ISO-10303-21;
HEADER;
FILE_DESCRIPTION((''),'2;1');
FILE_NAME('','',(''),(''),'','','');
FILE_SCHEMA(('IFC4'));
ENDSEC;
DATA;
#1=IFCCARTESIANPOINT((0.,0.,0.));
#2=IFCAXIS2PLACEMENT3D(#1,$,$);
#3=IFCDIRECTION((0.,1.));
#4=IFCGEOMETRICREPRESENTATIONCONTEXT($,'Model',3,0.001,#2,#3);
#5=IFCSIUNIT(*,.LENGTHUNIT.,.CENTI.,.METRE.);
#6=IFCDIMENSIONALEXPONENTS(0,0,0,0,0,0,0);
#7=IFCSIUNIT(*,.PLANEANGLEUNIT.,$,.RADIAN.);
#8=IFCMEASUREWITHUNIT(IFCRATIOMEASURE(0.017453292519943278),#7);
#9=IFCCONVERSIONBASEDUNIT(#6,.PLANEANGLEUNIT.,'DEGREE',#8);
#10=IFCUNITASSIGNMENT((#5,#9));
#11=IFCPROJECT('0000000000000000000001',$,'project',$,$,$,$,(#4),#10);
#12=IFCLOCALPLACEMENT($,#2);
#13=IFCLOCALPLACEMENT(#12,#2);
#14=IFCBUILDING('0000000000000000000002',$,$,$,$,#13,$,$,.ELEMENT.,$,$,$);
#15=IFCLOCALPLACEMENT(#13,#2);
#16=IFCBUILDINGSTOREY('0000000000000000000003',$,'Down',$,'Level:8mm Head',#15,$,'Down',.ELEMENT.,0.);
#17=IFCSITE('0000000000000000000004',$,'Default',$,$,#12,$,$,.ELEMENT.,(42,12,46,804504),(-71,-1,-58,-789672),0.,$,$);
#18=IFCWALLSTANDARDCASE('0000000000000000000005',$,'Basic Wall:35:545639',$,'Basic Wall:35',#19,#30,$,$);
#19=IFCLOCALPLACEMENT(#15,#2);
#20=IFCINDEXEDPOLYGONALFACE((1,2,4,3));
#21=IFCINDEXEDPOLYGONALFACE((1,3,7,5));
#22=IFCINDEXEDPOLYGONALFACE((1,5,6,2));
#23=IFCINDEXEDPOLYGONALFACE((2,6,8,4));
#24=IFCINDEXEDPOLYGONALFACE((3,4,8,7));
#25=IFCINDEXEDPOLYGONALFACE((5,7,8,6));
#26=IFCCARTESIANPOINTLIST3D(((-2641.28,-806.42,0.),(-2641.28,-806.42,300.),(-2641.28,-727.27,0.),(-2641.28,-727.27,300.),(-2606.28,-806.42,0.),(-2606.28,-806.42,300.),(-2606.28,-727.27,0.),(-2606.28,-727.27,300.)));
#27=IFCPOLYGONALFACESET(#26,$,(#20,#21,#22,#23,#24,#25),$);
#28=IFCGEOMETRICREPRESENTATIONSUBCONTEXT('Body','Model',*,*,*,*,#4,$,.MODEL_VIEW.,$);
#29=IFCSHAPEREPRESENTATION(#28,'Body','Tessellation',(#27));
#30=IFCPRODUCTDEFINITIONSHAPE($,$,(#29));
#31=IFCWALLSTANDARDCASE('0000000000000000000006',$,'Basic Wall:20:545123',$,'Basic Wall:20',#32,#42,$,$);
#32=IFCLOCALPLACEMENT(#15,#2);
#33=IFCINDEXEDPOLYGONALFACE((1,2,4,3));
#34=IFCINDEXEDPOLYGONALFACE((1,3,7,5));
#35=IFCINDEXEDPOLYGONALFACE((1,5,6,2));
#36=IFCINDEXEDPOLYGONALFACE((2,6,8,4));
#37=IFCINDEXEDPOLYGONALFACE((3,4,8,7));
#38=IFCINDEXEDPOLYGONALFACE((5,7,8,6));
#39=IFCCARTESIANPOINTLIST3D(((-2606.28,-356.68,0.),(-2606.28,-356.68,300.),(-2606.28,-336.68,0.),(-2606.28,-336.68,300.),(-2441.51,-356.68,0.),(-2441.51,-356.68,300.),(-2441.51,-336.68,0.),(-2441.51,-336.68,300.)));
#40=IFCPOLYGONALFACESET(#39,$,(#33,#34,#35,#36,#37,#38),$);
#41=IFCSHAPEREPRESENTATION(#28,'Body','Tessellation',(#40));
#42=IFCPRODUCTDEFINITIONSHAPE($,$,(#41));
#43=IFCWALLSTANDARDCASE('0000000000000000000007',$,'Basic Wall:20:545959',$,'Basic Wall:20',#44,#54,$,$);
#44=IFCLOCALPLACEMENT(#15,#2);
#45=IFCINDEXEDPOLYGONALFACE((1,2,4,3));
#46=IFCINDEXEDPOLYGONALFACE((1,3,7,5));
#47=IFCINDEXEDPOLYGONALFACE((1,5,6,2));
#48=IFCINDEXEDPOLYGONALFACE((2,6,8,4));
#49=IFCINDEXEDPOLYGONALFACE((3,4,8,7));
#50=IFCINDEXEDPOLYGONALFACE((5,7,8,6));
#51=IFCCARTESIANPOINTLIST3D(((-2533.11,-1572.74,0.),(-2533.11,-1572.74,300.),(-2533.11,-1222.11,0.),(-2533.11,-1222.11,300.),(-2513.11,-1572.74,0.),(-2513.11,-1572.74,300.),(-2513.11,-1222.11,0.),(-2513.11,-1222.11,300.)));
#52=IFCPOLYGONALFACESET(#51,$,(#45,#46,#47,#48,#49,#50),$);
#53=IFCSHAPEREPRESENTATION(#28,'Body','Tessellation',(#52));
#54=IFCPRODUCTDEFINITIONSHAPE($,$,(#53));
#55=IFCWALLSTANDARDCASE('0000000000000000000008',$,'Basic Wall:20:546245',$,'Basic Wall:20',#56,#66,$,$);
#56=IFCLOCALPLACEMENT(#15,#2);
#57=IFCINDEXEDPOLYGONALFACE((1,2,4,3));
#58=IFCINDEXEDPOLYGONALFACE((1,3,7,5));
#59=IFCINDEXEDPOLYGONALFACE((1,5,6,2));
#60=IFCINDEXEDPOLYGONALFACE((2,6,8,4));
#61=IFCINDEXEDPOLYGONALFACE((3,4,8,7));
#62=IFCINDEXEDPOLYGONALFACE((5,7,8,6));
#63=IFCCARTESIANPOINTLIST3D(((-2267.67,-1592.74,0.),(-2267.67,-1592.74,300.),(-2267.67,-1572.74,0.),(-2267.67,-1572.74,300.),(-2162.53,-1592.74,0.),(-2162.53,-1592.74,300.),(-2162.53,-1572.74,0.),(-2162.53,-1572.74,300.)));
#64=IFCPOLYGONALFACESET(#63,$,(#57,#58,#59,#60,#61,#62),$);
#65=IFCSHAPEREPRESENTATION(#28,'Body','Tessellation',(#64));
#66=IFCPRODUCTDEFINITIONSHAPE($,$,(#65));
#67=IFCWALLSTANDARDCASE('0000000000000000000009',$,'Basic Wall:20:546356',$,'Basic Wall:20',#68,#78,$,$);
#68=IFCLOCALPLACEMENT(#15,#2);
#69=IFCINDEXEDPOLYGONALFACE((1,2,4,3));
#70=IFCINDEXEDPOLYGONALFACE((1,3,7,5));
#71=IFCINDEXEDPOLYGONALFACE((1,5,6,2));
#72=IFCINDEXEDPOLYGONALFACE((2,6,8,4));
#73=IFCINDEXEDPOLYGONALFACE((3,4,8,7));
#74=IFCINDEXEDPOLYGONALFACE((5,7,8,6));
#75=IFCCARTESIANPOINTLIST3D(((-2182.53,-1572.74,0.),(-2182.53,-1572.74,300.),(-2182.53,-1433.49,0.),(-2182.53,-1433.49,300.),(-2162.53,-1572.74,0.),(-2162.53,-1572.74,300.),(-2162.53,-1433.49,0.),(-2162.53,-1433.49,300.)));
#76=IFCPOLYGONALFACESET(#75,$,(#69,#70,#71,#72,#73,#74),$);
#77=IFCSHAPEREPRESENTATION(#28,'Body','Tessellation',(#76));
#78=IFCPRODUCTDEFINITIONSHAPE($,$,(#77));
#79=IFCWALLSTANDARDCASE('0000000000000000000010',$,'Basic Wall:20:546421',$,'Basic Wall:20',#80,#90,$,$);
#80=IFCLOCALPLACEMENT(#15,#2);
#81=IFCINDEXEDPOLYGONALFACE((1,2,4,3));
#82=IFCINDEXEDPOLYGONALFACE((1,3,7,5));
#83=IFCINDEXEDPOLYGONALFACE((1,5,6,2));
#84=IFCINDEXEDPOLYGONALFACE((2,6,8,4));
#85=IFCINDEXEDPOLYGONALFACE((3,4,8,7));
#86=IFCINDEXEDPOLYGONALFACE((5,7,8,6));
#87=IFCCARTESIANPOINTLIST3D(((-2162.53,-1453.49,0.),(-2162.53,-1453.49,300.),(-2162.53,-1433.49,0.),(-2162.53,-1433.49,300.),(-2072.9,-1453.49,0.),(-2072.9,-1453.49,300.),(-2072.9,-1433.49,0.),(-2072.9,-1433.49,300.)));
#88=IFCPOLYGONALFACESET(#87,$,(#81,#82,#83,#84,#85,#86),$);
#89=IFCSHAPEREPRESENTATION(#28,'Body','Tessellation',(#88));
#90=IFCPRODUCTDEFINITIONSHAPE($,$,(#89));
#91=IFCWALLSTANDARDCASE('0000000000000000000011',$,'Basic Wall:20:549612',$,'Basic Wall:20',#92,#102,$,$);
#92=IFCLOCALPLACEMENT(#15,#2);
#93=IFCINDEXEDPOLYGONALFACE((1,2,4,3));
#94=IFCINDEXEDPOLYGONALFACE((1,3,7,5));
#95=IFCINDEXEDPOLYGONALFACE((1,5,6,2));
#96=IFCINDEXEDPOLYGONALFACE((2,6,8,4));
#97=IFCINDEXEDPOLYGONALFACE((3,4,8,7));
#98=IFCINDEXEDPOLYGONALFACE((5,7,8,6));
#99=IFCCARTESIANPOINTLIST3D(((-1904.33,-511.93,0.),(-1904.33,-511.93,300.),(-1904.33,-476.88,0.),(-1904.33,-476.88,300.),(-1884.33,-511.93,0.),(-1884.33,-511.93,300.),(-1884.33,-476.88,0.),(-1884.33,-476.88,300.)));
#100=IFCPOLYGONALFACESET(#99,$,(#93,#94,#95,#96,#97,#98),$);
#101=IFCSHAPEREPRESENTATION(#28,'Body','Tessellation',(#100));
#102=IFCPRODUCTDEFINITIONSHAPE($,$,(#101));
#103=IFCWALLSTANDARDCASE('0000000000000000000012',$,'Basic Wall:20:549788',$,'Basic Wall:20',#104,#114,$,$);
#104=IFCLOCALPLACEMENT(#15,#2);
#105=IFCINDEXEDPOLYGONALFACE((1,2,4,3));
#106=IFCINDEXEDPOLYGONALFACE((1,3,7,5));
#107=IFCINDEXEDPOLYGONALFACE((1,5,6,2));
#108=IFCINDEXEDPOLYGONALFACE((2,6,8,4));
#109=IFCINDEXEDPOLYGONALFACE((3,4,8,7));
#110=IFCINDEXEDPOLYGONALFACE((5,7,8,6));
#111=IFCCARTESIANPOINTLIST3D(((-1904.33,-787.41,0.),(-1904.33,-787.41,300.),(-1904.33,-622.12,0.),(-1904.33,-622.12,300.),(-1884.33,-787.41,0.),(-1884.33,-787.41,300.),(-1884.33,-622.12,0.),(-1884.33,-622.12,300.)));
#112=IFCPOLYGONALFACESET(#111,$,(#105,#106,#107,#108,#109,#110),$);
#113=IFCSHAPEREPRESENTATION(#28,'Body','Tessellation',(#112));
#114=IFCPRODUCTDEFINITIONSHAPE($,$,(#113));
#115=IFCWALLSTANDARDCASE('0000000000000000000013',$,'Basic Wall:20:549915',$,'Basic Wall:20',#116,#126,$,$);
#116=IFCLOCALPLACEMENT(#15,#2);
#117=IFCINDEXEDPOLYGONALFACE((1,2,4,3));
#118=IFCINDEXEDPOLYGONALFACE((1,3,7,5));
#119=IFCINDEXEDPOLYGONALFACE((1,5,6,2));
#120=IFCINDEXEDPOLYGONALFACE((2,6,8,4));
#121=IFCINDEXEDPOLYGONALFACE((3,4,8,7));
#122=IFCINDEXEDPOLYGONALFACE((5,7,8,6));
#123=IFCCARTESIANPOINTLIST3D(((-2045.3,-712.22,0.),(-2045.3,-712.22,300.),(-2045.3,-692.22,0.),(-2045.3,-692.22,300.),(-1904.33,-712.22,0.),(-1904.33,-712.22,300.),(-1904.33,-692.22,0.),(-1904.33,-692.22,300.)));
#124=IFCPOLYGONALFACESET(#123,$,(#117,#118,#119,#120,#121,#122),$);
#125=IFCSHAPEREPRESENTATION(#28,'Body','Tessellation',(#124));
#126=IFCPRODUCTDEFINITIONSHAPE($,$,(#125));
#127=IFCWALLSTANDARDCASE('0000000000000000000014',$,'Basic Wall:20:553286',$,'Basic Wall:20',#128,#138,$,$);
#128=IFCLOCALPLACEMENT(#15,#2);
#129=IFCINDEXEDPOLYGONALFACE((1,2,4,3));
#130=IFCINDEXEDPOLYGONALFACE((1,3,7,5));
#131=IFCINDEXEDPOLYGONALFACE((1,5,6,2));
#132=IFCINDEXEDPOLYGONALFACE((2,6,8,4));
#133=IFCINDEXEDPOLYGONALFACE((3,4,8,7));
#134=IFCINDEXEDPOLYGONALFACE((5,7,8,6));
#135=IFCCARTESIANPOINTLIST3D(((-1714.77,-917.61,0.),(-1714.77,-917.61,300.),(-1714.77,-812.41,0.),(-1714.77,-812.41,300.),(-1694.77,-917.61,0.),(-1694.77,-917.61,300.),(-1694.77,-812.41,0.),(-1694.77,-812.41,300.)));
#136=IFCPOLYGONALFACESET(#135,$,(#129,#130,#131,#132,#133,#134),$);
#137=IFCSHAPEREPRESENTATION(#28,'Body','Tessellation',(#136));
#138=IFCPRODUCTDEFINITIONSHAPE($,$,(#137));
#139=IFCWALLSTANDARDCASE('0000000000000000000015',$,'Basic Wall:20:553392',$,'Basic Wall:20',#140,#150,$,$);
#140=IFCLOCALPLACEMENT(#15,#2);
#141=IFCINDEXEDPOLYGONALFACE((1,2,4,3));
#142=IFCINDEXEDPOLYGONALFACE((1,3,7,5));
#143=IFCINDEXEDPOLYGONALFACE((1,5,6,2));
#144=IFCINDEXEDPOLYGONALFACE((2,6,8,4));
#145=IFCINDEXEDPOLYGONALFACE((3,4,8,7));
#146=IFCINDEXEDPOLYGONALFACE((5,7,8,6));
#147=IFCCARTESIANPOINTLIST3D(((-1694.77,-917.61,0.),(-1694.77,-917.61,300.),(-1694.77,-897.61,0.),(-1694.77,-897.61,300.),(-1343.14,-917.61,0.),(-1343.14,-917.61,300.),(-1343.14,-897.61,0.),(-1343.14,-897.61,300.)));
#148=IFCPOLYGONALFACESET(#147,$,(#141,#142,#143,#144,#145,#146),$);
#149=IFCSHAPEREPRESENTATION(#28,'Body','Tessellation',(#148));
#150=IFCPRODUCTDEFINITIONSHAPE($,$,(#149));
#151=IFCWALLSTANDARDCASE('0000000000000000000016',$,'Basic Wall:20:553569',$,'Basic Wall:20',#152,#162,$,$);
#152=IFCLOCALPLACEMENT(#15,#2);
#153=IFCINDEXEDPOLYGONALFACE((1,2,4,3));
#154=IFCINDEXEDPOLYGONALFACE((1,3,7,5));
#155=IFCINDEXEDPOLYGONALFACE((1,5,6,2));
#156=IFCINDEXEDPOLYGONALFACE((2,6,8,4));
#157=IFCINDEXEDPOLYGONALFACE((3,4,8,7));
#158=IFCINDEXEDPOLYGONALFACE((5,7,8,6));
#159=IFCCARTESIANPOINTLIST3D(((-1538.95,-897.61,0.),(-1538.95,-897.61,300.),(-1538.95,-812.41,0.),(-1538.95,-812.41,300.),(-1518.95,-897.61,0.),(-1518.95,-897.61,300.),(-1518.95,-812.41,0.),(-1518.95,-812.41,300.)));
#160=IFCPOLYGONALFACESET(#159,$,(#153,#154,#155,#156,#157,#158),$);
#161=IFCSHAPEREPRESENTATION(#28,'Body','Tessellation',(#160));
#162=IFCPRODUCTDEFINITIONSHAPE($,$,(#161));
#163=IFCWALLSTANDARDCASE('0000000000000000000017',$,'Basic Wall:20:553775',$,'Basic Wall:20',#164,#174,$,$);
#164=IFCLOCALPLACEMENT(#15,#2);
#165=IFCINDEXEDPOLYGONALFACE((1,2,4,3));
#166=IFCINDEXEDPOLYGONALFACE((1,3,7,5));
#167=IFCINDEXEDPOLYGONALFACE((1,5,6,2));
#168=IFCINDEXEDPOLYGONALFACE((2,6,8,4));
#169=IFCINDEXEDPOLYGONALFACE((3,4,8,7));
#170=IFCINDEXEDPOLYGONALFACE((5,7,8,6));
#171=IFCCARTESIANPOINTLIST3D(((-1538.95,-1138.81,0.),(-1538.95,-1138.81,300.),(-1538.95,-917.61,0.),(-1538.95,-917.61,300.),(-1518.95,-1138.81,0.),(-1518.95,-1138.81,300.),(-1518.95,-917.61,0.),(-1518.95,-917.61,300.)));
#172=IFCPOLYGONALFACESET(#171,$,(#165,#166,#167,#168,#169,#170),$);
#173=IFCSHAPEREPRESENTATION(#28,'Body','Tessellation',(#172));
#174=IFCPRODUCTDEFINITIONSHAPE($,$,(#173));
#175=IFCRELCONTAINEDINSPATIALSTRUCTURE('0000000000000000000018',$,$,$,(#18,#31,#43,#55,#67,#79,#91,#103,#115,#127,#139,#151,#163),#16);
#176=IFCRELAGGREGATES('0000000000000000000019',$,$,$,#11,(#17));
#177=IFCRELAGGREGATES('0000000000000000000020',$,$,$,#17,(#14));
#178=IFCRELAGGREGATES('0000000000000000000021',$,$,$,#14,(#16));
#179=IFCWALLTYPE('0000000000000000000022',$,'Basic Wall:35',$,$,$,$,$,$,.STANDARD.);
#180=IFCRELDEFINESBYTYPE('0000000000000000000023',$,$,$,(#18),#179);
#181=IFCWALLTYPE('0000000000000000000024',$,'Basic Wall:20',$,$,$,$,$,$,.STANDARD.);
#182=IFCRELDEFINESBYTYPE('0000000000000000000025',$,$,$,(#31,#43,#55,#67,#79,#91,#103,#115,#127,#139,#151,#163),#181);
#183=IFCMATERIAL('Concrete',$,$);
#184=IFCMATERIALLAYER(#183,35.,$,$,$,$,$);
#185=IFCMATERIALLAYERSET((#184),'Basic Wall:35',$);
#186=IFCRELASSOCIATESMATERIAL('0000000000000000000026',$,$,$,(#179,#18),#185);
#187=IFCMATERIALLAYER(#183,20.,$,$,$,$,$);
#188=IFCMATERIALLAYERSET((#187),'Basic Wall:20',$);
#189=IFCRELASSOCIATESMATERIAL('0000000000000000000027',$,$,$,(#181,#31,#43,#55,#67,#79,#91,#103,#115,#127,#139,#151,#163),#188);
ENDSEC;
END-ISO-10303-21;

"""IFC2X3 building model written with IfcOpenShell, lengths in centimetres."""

from ifc_helpers import new_model, entity, si_unit, converted_unit, direction, frame, frame_2d, origin, place, context, subcontext, project, spatial, rectangle, extrude, material, layer, layer_set, layer_usage, type_object, element, save


model = new_model("IFC2X3")

# Units and contexts
model_context = context("Model", 3, precision=0.001, world=origin(), true_north=direction((0.0, 1.0)))
body_context = subcontext(model_context, "Body", "Model", "MODEL_VIEW")
ifc_project = project(units=[si_unit("LENGTHUNIT", "METRE", prefix="CENTI"), converted_unit("PLANEANGLEUNIT", "DEGREE", entity("IfcRatioMeasure", 0.017453292519943278), si_unit("PLANEANGLEUNIT", "RADIAN"), dimensions=[0, 0, 0, 0, 0, 0, 0])], contexts=[model_context])

# Site, building, storey
site_placement = place(None, origin())
site = spatial("IfcSite", under=ifc_project, at=site_placement, Name="Default", CompositionType="ELEMENT", RefLatitude=(42, 12, 46, 804504), RefLongitude=(-71, -1, -58, -789672), RefElevation=0.0)
building_placement = place(site_placement, origin())
building = spatial("IfcBuilding", under=site, at=building_placement, CompositionType="ELEMENT")
storey_placement = place(building_placement, origin())
storey = spatial("IfcBuildingStorey", under=building, at=storey_placement, Name="Down", ObjectType="Level:8mm Head", LongName="Down", CompositionType="ELEMENT", Elevation=0.0)

# Walls
ifc_material = material(Name="Concrete")
ifc_layer_1 = layer(ifc_material, 35.0)
ifc_layer_set_1 = layer_set([ifc_layer_1], Name="Basic Wall:35")
ifc_layer_usage_1 = layer_usage(ifc_layer_set_1, "AXIS2", "NEGATIVE", 17.5)
wall_type_1 = type_object("IfcWallType", Name="Basic Wall:35", PredefinedType="STANDARD", material=ifc_layer_set_1)
wall_1_placement = place(storey_placement, frame((-2623.78, -727.27, 0.0), z_axis=(0.0, 0.0, 1.0), x_axis=(0.0, -1.0, 0.0)))
element("IfcWallStandardCase", 1, at=wall_1_placement, inside=storey, type_object=wall_type_1, material=ifc_layer_usage_1, Name="Basic Wall:35:545639", ObjectType="Basic Wall:35", context=body_context, shape_type="SweptSolid", body=[
    extrude(rectangle(XDim=79.16, YDim=35.0, at=frame_2d((39.58, 0.0), x_axis=(-1.0, 0.0))), origin(), (0.0, 0.0, 1.0), 300.0),
])
ifc_layer_2 = layer(ifc_material, 20.0)
ifc_layer_set_2 = layer_set([ifc_layer_2], Name="Basic Wall:20")
ifc_layer_usage_2 = layer_usage(ifc_layer_set_2, "AXIS2", "NEGATIVE", 10.0)
wall_type_2 = type_object("IfcWallType", Name="Basic Wall:20", PredefinedType="STANDARD", material=ifc_layer_set_2)
wall_2_placement = place(storey_placement, frame((-2441.51, -346.68, 0.0), z_axis=(0.0, 0.0, 1.0), x_axis=(-1.0, 0.0, 0.0)))
element("IfcWallStandardCase", 2, at=wall_2_placement, inside=storey, type_object=wall_type_2, material=ifc_layer_usage_2, Name="Basic Wall:20:545123", ObjectType="Basic Wall:20", context=body_context, shape_type="SweptSolid", body=[
    extrude(rectangle(XDim=164.77, YDim=20.0, at=frame_2d((82.39, 0.0), x_axis=(-1.0, 0.0))), origin(), (0.0, 0.0, 1.0), 300.0),
])
ifc_layer_usage_3 = layer_usage(ifc_layer_set_2, "AXIS2", "NEGATIVE", 10.0)
wall_3_placement = place(storey_placement, frame((-2523.11, -1222.11, 0.0), z_axis=(0.0, 0.0, 1.0), x_axis=(0.0, -1.0, 0.0)))
element("IfcWallStandardCase", 3, at=wall_3_placement, inside=storey, type_object=wall_type_2, material=ifc_layer_usage_3, Name="Basic Wall:20:545959", ObjectType="Basic Wall:20", context=body_context, shape_type="SweptSolid", body=[
    extrude(rectangle(XDim=350.64, YDim=20.0, at=frame_2d((175.32, 0.0), x_axis=(-1.0, 0.0))), origin(), (0.0, 0.0, 1.0), 300.0),
])
ifc_layer_usage_4 = layer_usage(ifc_layer_set_2, "AXIS2", "POSITIVE", -10.0)
wall_4_placement = place(storey_placement, frame((-2267.67, -1582.74, 0.0)))
element("IfcWallStandardCase", 4, at=wall_4_placement, inside=storey, type_object=wall_type_2, material=ifc_layer_usage_4, Name="Basic Wall:20:546245", ObjectType="Basic Wall:20", context=body_context, shape_type="SweptSolid", body=[
    extrude(rectangle(XDim=105.14, YDim=20.0, at=frame_2d((52.57, 0.0), x_axis=(-1.0, 0.0))), origin(), (0.0, 0.0, 1.0), 300.0),
])
ifc_layer_usage_5 = layer_usage(ifc_layer_set_2, "AXIS2", "POSITIVE", -10.0)
wall_5_placement = place(storey_placement, frame((-2172.53, -1572.74, 0.0), z_axis=(0.0, 0.0, 1.0), x_axis=(0.0, 1.0, 0.0)))
element("IfcWallStandardCase", 5, at=wall_5_placement, inside=storey, type_object=wall_type_2, material=ifc_layer_usage_5, Name="Basic Wall:20:546356", ObjectType="Basic Wall:20", context=body_context, shape_type="SweptSolid", body=[
    extrude(rectangle(XDim=139.25, YDim=20.0, at=frame_2d((69.63, 0.0), x_axis=(-1.0, 0.0))), origin(), (0.0, 0.0, 1.0), 300.0),
])
ifc_layer_usage_6 = layer_usage(ifc_layer_set_2, "AXIS2", "NEGATIVE", 10.0)
wall_6_placement = place(storey_placement, frame((-2162.53, -1443.49, 0.0)))
element("IfcWallStandardCase", 6, at=wall_6_placement, inside=storey, type_object=wall_type_2, material=ifc_layer_usage_6, Name="Basic Wall:20:546421", ObjectType="Basic Wall:20", context=body_context, shape_type="SweptSolid", body=[
    extrude(rectangle(XDim=89.63, YDim=20.0, at=frame_2d((44.81, 0.0), x_axis=(-1.0, 0.0))), origin(), (0.0, 0.0, 1.0), 300.0),
])
ifc_layer_usage_7 = layer_usage(ifc_layer_set_2, "AXIS2", "POSITIVE", -10.0)
wall_7_placement = place(storey_placement, frame((-1894.33, -476.88, 0.0), z_axis=(0.0, 0.0, 1.0), x_axis=(0.0, -1.0, 0.0)))
element("IfcWallStandardCase", 7, at=wall_7_placement, inside=storey, type_object=wall_type_2, material=ifc_layer_usage_7, Name="Basic Wall:20:549612", ObjectType="Basic Wall:20", context=body_context, shape_type="SweptSolid", body=[
    extrude(rectangle(XDim=35.05, YDim=20.0, at=frame_2d((17.52, 0.0), x_axis=(-1.0, 0.0))), origin(), (0.0, 0.0, 1.0), 300.0),
])
ifc_layer_usage_8 = layer_usage(ifc_layer_set_2, "AXIS2", "POSITIVE", -10.0)
wall_8_placement = place(storey_placement, frame((-1894.33, -622.12, 0.0), z_axis=(0.0, 0.0, 1.0), x_axis=(0.0, -1.0, 0.0)))
element("IfcWallStandardCase", 8, at=wall_8_placement, inside=storey, type_object=wall_type_2, material=ifc_layer_usage_8, Name="Basic Wall:20:549788", ObjectType="Basic Wall:20", context=body_context, shape_type="SweptSolid", body=[
    extrude(rectangle(XDim=165.29, YDim=20.0, at=frame_2d((82.65, 0.0), x_axis=(-1.0, 0.0))), origin(), (0.0, 0.0, 1.0), 300.0),
])
ifc_layer_usage_9 = layer_usage(ifc_layer_set_2, "AXIS2", "POSITIVE", -10.0)
wall_9_placement = place(storey_placement, frame((-1904.33, -702.22, 0.0), z_axis=(0.0, 0.0, 1.0), x_axis=(-1.0, 0.0, 0.0)))
element("IfcWallStandardCase", 9, at=wall_9_placement, inside=storey, type_object=wall_type_2, material=ifc_layer_usage_9, Name="Basic Wall:20:549915", ObjectType="Basic Wall:20", context=body_context, shape_type="SweptSolid", body=[
    extrude(rectangle(XDim=140.97, YDim=20.0, at=frame_2d((70.49, 0.0), x_axis=(-1.0, 0.0))), origin(), (0.0, 0.0, 1.0), 300.0),
])
ifc_layer_usage_10 = layer_usage(ifc_layer_set_2, "AXIS2", "POSITIVE", -10.0)
wall_10_placement = place(storey_placement, frame((-1704.77, -812.41, 0.0), z_axis=(0.0, 0.0, 1.0), x_axis=(0.0, -1.0, 0.0)))
element("IfcWallStandardCase", 10, at=wall_10_placement, inside=storey, type_object=wall_type_2, material=ifc_layer_usage_10, Name="Basic Wall:20:553286", ObjectType="Basic Wall:20", context=body_context, shape_type="SweptSolid", body=[
    extrude(rectangle(XDim=105.2, YDim=20.0, at=frame_2d((52.6, 0.0), x_axis=(-1.0, 0.0))), origin(), (0.0, 0.0, 1.0), 300.0),
])
ifc_layer_usage_11 = layer_usage(ifc_layer_set_2, "AXIS2", "POSITIVE", -10.0)
wall_11_placement = place(storey_placement, frame((-1694.77, -907.61, 0.0)))
element("IfcWallStandardCase", 11, at=wall_11_placement, inside=storey, type_object=wall_type_2, material=ifc_layer_usage_11, Name="Basic Wall:20:553392", ObjectType="Basic Wall:20", context=body_context, shape_type="SweptSolid", body=[
    extrude(rectangle(XDim=351.62, YDim=20.0, at=frame_2d((175.81, 0.0), x_axis=(-1.0, 0.0))), origin(), (0.0, 0.0, 1.0), 300.0),
])
ifc_layer_usage_12 = layer_usage(ifc_layer_set_2, "AXIS2", "NEGATIVE", 10.0)
wall_12_placement = place(storey_placement, frame((-1528.95, -812.41, 0.0), z_axis=(0.0, 0.0, 1.0), x_axis=(0.0, -1.0, 0.0)))
element("IfcWallStandardCase", 12, at=wall_12_placement, inside=storey, type_object=wall_type_2, material=ifc_layer_usage_12, Name="Basic Wall:20:553569", ObjectType="Basic Wall:20", context=body_context, shape_type="SweptSolid", body=[
    extrude(rectangle(XDim=85.2, YDim=20.0, at=frame_2d((42.6, 0.0), x_axis=(-1.0, 0.0))), origin(), (0.0, 0.0, 1.0), 300.0),
])
ifc_layer_usage_13 = layer_usage(ifc_layer_set_2, "AXIS2", "POSITIVE", -10.0)
wall_13_placement = place(storey_placement, frame((-1528.95, -917.61, 0.0), z_axis=(0.0, 0.0, 1.0), x_axis=(0.0, -1.0, 0.0)))
element("IfcWallStandardCase", 13, at=wall_13_placement, inside=storey, type_object=wall_type_2, material=ifc_layer_usage_13, Name="Basic Wall:20:553775", ObjectType="Basic Wall:20", context=body_context, shape_type="SweptSolid", body=[
    extrude(rectangle(XDim=221.2, YDim=20.0, at=frame_2d((110.6, 0.0), x_axis=(-1.0, 0.0))), origin(), (0.0, 0.0, 1.0), 300.0),
])

save(model, "model.ifc")
